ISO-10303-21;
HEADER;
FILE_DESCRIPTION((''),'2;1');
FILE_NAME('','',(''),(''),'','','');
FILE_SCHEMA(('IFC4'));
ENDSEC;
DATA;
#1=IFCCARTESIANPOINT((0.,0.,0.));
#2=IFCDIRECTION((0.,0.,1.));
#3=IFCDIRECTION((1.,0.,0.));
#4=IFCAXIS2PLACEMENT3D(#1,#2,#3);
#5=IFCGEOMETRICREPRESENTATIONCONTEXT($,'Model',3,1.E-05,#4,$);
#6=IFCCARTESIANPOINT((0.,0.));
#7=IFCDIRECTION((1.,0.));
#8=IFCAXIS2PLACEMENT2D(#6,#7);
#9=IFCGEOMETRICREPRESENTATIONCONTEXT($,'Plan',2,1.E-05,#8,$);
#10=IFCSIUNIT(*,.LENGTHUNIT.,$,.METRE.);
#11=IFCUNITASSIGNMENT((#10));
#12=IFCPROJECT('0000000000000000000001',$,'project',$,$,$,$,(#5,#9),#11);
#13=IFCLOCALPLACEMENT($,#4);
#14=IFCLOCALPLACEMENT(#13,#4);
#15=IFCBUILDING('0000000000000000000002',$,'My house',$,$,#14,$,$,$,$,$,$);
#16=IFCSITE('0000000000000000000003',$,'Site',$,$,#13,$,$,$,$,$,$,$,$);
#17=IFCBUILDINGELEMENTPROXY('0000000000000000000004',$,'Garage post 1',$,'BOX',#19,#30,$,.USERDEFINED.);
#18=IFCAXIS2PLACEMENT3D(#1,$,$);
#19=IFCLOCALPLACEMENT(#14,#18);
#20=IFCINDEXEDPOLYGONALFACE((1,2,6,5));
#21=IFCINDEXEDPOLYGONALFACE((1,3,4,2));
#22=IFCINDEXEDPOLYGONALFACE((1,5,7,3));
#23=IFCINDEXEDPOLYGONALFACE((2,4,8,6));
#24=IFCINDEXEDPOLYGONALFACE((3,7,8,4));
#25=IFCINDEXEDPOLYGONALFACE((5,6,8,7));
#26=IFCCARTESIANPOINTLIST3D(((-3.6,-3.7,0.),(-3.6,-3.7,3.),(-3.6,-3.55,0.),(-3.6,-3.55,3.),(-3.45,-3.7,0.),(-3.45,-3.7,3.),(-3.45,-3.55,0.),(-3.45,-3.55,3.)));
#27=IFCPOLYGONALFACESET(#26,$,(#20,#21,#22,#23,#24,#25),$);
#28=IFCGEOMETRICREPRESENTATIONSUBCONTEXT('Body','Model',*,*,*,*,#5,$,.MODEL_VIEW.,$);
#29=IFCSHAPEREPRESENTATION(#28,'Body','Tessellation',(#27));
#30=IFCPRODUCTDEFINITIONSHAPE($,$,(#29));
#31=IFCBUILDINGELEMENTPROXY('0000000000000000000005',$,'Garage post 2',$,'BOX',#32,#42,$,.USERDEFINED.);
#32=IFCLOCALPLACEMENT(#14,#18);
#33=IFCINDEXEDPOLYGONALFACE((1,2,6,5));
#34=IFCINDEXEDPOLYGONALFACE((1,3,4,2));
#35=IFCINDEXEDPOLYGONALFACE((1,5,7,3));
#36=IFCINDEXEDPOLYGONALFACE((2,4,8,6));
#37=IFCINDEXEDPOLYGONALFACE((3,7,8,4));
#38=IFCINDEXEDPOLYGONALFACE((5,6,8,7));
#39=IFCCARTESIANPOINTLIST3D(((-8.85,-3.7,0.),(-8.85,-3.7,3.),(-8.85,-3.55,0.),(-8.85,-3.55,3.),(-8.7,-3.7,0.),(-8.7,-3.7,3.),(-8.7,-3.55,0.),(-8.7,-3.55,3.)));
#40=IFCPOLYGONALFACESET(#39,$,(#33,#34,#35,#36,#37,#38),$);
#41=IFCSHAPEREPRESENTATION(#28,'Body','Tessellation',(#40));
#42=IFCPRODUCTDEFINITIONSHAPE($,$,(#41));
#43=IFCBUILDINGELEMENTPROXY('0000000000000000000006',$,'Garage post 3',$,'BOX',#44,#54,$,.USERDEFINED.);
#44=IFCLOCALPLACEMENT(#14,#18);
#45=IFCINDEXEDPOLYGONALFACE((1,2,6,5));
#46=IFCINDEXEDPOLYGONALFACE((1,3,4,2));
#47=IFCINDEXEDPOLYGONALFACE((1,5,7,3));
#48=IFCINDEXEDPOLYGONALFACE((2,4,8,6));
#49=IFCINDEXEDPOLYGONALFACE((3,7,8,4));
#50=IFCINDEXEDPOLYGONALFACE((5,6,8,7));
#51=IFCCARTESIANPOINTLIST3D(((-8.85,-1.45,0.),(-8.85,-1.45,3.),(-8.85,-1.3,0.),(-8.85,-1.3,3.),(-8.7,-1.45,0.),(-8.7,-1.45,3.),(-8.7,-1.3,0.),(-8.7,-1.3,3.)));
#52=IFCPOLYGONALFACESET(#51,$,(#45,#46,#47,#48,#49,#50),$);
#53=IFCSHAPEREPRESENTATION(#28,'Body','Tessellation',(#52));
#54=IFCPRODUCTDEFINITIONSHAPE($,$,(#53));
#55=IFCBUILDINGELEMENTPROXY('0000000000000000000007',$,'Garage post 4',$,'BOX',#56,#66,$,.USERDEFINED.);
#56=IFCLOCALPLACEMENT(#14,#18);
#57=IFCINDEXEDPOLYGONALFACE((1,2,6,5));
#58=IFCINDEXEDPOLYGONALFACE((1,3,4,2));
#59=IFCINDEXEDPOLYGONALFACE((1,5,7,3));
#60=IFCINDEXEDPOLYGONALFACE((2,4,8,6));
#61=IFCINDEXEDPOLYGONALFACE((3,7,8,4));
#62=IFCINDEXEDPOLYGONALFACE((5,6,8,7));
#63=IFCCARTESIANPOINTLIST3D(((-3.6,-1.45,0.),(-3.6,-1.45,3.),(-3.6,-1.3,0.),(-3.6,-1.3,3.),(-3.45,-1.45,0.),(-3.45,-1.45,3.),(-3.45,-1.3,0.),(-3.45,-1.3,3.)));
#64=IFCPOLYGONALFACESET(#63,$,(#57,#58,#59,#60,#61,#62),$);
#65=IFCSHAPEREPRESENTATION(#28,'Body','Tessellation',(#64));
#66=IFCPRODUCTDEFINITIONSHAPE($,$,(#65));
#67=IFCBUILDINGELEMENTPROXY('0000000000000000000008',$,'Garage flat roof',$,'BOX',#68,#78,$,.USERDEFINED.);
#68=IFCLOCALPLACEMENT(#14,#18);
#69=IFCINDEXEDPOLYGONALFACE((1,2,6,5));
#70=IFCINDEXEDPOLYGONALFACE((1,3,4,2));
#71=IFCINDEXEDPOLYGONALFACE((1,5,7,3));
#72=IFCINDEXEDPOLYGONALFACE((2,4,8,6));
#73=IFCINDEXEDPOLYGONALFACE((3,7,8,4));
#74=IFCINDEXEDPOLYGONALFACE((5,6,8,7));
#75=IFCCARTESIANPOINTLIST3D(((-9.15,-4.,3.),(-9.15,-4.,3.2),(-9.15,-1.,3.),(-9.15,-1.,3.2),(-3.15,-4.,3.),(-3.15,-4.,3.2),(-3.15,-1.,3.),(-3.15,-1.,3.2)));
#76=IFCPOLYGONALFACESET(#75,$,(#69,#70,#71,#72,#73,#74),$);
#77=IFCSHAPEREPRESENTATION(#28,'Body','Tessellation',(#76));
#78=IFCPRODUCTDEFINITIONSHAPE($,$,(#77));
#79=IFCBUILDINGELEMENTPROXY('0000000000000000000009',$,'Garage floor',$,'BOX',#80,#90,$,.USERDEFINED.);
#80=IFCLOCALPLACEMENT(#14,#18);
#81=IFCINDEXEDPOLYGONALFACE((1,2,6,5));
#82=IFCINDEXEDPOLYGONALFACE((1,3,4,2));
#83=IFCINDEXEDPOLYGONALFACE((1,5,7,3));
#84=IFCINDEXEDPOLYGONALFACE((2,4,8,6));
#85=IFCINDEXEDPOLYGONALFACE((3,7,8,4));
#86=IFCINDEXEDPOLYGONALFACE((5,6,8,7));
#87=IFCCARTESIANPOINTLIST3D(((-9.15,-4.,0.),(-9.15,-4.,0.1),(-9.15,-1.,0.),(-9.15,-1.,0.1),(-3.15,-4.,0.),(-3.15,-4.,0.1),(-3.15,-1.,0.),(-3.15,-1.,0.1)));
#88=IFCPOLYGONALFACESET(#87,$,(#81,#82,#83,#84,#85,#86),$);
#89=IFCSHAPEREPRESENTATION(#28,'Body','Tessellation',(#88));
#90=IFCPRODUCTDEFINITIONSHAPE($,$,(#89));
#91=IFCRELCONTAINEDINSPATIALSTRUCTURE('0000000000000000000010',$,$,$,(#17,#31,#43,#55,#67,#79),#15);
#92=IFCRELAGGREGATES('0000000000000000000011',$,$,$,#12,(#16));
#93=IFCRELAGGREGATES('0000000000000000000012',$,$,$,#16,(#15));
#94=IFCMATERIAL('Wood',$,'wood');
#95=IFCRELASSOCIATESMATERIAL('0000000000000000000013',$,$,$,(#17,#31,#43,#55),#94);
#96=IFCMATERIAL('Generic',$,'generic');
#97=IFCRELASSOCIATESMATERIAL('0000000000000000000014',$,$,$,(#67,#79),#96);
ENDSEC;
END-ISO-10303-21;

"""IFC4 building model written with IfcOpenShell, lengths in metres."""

from ifc_helpers import new_model, si_unit, frame, origin_with_axes, origin_2d_with_axis, place, context, subcontext, project, spatial, rectangle, extrude, source, transform, mapped, material, element, save


model = new_model("IFC4")

# Units and contexts
model_context = context("Model", 3, precision=1e-05, world=origin_with_axes())
plan_context = context("Plan", 2, precision=1e-05, world=origin_2d_with_axis())
body_context = subcontext(model_context, "Body", "Model", "MODEL_VIEW")
ifc_project = project(units=[si_unit("LENGTHUNIT", "METRE")], contexts=[model_context, plan_context])

# Site, building
site_placement = place(None, origin_with_axes())
site = spatial("IfcSite", under=ifc_project, at=site_placement, Name="Site")
building_placement = place(site_placement, origin_with_axes())
building = spatial("IfcBuilding", under=site, at=building_placement, Name="My house")

# Building element proxies
ifc_material_1 = material(Name="Wood", Category="wood")
shared_shape_1 = source(origin_with_axes(), body_context, "Body", "SweptSolid", [
    extrude(rectangle(XDim=0.15, YDim=0.15), origin_with_axes(), (0.0, 0.0, 1.0), 3.0),
])
proxy_1_placement = place(building_placement, frame((-3.525, -3.625, 0.0), z_axis=(0.0, 0.0, 1.0), x_axis=(1.0, 0.0, 0.0)))
element("IfcBuildingElementProxy", 1, at=proxy_1_placement, inside=building, material=ifc_material_1, Name="Garage post 1", ObjectType="BOX", PredefinedType="USERDEFINED", context=body_context, shape_type="MappedRepresentation", body=[
    mapped(shared_shape_1, transform((0.0, 0.0, 0.0), x_axis=(-1.0, 0.0, 0.0), y_axis=(0.0, 1.0, 0.0), z_axis=(0.0, 0.0, 1.0), scale=1.0)),
])
shared_shape_2 = source(origin_with_axes(), body_context, "Body", "SweptSolid", [
    extrude(rectangle(XDim=0.15, YDim=0.15), origin_with_axes(), (0.0, 0.0, 1.0), 3.0),
])
proxy_2_placement = place(building_placement, frame((-8.775, -3.625, 0.0), z_axis=(0.0, 0.0, 1.0), x_axis=(1.0, 0.0, 0.0)))
element("IfcBuildingElementProxy", 2, at=proxy_2_placement, inside=building, material=ifc_material_1, Name="Garage post 2", ObjectType="BOX", PredefinedType="USERDEFINED", context=body_context, shape_type="MappedRepresentation", body=[
    mapped(shared_shape_2, transform((0.0, 0.0, 0.0), x_axis=(-1.0, 0.0, 0.0), y_axis=(0.0, 1.0, 0.0), z_axis=(0.0, 0.0, 1.0), scale=1.0)),
])
shared_shape_3 = source(origin_with_axes(), body_context, "Body", "SweptSolid", [
    extrude(rectangle(XDim=0.15, YDim=0.15), origin_with_axes(), (0.0, 0.0, 1.0), 3.0),
])
proxy_3_placement = place(building_placement, frame((-8.775, -1.375, 0.0), z_axis=(0.0, 0.0, 1.0), x_axis=(1.0, 0.0, 0.0)))
element("IfcBuildingElementProxy", 3, at=proxy_3_placement, inside=building, material=ifc_material_1, Name="Garage post 3", ObjectType="BOX", PredefinedType="USERDEFINED", context=body_context, shape_type="MappedRepresentation", body=[
    mapped(shared_shape_3, transform((0.0, 0.0, 0.0), x_axis=(-1.0, 0.0, 0.0), y_axis=(0.0, 1.0, 0.0), z_axis=(0.0, 0.0, 1.0), scale=1.0)),
])
shared_shape_4 = source(origin_with_axes(), body_context, "Body", "SweptSolid", [
    extrude(rectangle(XDim=0.15, YDim=0.15), origin_with_axes(), (0.0, 0.0, 1.0), 3.0),
])
proxy_4_placement = place(building_placement, frame((-3.525, -1.375, 0.0), z_axis=(0.0, 0.0, 1.0), x_axis=(1.0, 0.0, 0.0)))
element("IfcBuildingElementProxy", 4, at=proxy_4_placement, inside=building, material=ifc_material_1, Name="Garage post 4", ObjectType="BOX", PredefinedType="USERDEFINED", context=body_context, shape_type="MappedRepresentation", body=[
    mapped(shared_shape_4, transform((0.0, 0.0, 0.0), x_axis=(-1.0, 0.0, 0.0), y_axis=(0.0, 1.0, 0.0), z_axis=(0.0, 0.0, 1.0), scale=1.0)),
])
ifc_material_2 = material(Name="Generic", Category="generic")
shared_shape_5 = source(origin_with_axes(), body_context, "Body", "SweptSolid", [
    extrude(rectangle(XDim=6.0, YDim=3.0), origin_with_axes(), (0.0, 0.0, 1.0), 0.2),
])
proxy_5_placement = place(building_placement, frame((-6.15, -2.5, 3.0), z_axis=(0.0, 0.0, 1.0), x_axis=(1.0, 0.0, 0.0)))
element("IfcBuildingElementProxy", 5, at=proxy_5_placement, inside=building, material=ifc_material_2, Name="Garage flat roof", ObjectType="BOX", PredefinedType="USERDEFINED", context=body_context, shape_type="MappedRepresentation", body=[
    mapped(shared_shape_5, transform((0.0, 0.0, 0.0), x_axis=(-1.0, 0.0, 0.0), y_axis=(0.0, 1.0, 0.0), z_axis=(0.0, 0.0, 1.0), scale=1.0)),
])
shared_shape_6 = source(origin_with_axes(), body_context, "Body", "SweptSolid", [
    extrude(rectangle(XDim=6.0, YDim=3.0), origin_with_axes(), (0.0, 0.0, 1.0), 0.1),
])
proxy_6_placement = place(building_placement, frame((-6.15, -2.5, 0.0), z_axis=(0.0, 0.0, 1.0), x_axis=(1.0, 0.0, 0.0)))
element("IfcBuildingElementProxy", 6, at=proxy_6_placement, inside=building, material=ifc_material_2, Name="Garage floor", ObjectType="BOX", PredefinedType="USERDEFINED", context=body_context, shape_type="MappedRepresentation", body=[
    mapped(shared_shape_6, transform((0.0, 0.0, 0.0), x_axis=(-1.0, 0.0, 0.0), y_axis=(0.0, 1.0, 0.0), z_axis=(0.0, 0.0, 1.0), scale=1.0)),
])

save(model, "model.ifc")
